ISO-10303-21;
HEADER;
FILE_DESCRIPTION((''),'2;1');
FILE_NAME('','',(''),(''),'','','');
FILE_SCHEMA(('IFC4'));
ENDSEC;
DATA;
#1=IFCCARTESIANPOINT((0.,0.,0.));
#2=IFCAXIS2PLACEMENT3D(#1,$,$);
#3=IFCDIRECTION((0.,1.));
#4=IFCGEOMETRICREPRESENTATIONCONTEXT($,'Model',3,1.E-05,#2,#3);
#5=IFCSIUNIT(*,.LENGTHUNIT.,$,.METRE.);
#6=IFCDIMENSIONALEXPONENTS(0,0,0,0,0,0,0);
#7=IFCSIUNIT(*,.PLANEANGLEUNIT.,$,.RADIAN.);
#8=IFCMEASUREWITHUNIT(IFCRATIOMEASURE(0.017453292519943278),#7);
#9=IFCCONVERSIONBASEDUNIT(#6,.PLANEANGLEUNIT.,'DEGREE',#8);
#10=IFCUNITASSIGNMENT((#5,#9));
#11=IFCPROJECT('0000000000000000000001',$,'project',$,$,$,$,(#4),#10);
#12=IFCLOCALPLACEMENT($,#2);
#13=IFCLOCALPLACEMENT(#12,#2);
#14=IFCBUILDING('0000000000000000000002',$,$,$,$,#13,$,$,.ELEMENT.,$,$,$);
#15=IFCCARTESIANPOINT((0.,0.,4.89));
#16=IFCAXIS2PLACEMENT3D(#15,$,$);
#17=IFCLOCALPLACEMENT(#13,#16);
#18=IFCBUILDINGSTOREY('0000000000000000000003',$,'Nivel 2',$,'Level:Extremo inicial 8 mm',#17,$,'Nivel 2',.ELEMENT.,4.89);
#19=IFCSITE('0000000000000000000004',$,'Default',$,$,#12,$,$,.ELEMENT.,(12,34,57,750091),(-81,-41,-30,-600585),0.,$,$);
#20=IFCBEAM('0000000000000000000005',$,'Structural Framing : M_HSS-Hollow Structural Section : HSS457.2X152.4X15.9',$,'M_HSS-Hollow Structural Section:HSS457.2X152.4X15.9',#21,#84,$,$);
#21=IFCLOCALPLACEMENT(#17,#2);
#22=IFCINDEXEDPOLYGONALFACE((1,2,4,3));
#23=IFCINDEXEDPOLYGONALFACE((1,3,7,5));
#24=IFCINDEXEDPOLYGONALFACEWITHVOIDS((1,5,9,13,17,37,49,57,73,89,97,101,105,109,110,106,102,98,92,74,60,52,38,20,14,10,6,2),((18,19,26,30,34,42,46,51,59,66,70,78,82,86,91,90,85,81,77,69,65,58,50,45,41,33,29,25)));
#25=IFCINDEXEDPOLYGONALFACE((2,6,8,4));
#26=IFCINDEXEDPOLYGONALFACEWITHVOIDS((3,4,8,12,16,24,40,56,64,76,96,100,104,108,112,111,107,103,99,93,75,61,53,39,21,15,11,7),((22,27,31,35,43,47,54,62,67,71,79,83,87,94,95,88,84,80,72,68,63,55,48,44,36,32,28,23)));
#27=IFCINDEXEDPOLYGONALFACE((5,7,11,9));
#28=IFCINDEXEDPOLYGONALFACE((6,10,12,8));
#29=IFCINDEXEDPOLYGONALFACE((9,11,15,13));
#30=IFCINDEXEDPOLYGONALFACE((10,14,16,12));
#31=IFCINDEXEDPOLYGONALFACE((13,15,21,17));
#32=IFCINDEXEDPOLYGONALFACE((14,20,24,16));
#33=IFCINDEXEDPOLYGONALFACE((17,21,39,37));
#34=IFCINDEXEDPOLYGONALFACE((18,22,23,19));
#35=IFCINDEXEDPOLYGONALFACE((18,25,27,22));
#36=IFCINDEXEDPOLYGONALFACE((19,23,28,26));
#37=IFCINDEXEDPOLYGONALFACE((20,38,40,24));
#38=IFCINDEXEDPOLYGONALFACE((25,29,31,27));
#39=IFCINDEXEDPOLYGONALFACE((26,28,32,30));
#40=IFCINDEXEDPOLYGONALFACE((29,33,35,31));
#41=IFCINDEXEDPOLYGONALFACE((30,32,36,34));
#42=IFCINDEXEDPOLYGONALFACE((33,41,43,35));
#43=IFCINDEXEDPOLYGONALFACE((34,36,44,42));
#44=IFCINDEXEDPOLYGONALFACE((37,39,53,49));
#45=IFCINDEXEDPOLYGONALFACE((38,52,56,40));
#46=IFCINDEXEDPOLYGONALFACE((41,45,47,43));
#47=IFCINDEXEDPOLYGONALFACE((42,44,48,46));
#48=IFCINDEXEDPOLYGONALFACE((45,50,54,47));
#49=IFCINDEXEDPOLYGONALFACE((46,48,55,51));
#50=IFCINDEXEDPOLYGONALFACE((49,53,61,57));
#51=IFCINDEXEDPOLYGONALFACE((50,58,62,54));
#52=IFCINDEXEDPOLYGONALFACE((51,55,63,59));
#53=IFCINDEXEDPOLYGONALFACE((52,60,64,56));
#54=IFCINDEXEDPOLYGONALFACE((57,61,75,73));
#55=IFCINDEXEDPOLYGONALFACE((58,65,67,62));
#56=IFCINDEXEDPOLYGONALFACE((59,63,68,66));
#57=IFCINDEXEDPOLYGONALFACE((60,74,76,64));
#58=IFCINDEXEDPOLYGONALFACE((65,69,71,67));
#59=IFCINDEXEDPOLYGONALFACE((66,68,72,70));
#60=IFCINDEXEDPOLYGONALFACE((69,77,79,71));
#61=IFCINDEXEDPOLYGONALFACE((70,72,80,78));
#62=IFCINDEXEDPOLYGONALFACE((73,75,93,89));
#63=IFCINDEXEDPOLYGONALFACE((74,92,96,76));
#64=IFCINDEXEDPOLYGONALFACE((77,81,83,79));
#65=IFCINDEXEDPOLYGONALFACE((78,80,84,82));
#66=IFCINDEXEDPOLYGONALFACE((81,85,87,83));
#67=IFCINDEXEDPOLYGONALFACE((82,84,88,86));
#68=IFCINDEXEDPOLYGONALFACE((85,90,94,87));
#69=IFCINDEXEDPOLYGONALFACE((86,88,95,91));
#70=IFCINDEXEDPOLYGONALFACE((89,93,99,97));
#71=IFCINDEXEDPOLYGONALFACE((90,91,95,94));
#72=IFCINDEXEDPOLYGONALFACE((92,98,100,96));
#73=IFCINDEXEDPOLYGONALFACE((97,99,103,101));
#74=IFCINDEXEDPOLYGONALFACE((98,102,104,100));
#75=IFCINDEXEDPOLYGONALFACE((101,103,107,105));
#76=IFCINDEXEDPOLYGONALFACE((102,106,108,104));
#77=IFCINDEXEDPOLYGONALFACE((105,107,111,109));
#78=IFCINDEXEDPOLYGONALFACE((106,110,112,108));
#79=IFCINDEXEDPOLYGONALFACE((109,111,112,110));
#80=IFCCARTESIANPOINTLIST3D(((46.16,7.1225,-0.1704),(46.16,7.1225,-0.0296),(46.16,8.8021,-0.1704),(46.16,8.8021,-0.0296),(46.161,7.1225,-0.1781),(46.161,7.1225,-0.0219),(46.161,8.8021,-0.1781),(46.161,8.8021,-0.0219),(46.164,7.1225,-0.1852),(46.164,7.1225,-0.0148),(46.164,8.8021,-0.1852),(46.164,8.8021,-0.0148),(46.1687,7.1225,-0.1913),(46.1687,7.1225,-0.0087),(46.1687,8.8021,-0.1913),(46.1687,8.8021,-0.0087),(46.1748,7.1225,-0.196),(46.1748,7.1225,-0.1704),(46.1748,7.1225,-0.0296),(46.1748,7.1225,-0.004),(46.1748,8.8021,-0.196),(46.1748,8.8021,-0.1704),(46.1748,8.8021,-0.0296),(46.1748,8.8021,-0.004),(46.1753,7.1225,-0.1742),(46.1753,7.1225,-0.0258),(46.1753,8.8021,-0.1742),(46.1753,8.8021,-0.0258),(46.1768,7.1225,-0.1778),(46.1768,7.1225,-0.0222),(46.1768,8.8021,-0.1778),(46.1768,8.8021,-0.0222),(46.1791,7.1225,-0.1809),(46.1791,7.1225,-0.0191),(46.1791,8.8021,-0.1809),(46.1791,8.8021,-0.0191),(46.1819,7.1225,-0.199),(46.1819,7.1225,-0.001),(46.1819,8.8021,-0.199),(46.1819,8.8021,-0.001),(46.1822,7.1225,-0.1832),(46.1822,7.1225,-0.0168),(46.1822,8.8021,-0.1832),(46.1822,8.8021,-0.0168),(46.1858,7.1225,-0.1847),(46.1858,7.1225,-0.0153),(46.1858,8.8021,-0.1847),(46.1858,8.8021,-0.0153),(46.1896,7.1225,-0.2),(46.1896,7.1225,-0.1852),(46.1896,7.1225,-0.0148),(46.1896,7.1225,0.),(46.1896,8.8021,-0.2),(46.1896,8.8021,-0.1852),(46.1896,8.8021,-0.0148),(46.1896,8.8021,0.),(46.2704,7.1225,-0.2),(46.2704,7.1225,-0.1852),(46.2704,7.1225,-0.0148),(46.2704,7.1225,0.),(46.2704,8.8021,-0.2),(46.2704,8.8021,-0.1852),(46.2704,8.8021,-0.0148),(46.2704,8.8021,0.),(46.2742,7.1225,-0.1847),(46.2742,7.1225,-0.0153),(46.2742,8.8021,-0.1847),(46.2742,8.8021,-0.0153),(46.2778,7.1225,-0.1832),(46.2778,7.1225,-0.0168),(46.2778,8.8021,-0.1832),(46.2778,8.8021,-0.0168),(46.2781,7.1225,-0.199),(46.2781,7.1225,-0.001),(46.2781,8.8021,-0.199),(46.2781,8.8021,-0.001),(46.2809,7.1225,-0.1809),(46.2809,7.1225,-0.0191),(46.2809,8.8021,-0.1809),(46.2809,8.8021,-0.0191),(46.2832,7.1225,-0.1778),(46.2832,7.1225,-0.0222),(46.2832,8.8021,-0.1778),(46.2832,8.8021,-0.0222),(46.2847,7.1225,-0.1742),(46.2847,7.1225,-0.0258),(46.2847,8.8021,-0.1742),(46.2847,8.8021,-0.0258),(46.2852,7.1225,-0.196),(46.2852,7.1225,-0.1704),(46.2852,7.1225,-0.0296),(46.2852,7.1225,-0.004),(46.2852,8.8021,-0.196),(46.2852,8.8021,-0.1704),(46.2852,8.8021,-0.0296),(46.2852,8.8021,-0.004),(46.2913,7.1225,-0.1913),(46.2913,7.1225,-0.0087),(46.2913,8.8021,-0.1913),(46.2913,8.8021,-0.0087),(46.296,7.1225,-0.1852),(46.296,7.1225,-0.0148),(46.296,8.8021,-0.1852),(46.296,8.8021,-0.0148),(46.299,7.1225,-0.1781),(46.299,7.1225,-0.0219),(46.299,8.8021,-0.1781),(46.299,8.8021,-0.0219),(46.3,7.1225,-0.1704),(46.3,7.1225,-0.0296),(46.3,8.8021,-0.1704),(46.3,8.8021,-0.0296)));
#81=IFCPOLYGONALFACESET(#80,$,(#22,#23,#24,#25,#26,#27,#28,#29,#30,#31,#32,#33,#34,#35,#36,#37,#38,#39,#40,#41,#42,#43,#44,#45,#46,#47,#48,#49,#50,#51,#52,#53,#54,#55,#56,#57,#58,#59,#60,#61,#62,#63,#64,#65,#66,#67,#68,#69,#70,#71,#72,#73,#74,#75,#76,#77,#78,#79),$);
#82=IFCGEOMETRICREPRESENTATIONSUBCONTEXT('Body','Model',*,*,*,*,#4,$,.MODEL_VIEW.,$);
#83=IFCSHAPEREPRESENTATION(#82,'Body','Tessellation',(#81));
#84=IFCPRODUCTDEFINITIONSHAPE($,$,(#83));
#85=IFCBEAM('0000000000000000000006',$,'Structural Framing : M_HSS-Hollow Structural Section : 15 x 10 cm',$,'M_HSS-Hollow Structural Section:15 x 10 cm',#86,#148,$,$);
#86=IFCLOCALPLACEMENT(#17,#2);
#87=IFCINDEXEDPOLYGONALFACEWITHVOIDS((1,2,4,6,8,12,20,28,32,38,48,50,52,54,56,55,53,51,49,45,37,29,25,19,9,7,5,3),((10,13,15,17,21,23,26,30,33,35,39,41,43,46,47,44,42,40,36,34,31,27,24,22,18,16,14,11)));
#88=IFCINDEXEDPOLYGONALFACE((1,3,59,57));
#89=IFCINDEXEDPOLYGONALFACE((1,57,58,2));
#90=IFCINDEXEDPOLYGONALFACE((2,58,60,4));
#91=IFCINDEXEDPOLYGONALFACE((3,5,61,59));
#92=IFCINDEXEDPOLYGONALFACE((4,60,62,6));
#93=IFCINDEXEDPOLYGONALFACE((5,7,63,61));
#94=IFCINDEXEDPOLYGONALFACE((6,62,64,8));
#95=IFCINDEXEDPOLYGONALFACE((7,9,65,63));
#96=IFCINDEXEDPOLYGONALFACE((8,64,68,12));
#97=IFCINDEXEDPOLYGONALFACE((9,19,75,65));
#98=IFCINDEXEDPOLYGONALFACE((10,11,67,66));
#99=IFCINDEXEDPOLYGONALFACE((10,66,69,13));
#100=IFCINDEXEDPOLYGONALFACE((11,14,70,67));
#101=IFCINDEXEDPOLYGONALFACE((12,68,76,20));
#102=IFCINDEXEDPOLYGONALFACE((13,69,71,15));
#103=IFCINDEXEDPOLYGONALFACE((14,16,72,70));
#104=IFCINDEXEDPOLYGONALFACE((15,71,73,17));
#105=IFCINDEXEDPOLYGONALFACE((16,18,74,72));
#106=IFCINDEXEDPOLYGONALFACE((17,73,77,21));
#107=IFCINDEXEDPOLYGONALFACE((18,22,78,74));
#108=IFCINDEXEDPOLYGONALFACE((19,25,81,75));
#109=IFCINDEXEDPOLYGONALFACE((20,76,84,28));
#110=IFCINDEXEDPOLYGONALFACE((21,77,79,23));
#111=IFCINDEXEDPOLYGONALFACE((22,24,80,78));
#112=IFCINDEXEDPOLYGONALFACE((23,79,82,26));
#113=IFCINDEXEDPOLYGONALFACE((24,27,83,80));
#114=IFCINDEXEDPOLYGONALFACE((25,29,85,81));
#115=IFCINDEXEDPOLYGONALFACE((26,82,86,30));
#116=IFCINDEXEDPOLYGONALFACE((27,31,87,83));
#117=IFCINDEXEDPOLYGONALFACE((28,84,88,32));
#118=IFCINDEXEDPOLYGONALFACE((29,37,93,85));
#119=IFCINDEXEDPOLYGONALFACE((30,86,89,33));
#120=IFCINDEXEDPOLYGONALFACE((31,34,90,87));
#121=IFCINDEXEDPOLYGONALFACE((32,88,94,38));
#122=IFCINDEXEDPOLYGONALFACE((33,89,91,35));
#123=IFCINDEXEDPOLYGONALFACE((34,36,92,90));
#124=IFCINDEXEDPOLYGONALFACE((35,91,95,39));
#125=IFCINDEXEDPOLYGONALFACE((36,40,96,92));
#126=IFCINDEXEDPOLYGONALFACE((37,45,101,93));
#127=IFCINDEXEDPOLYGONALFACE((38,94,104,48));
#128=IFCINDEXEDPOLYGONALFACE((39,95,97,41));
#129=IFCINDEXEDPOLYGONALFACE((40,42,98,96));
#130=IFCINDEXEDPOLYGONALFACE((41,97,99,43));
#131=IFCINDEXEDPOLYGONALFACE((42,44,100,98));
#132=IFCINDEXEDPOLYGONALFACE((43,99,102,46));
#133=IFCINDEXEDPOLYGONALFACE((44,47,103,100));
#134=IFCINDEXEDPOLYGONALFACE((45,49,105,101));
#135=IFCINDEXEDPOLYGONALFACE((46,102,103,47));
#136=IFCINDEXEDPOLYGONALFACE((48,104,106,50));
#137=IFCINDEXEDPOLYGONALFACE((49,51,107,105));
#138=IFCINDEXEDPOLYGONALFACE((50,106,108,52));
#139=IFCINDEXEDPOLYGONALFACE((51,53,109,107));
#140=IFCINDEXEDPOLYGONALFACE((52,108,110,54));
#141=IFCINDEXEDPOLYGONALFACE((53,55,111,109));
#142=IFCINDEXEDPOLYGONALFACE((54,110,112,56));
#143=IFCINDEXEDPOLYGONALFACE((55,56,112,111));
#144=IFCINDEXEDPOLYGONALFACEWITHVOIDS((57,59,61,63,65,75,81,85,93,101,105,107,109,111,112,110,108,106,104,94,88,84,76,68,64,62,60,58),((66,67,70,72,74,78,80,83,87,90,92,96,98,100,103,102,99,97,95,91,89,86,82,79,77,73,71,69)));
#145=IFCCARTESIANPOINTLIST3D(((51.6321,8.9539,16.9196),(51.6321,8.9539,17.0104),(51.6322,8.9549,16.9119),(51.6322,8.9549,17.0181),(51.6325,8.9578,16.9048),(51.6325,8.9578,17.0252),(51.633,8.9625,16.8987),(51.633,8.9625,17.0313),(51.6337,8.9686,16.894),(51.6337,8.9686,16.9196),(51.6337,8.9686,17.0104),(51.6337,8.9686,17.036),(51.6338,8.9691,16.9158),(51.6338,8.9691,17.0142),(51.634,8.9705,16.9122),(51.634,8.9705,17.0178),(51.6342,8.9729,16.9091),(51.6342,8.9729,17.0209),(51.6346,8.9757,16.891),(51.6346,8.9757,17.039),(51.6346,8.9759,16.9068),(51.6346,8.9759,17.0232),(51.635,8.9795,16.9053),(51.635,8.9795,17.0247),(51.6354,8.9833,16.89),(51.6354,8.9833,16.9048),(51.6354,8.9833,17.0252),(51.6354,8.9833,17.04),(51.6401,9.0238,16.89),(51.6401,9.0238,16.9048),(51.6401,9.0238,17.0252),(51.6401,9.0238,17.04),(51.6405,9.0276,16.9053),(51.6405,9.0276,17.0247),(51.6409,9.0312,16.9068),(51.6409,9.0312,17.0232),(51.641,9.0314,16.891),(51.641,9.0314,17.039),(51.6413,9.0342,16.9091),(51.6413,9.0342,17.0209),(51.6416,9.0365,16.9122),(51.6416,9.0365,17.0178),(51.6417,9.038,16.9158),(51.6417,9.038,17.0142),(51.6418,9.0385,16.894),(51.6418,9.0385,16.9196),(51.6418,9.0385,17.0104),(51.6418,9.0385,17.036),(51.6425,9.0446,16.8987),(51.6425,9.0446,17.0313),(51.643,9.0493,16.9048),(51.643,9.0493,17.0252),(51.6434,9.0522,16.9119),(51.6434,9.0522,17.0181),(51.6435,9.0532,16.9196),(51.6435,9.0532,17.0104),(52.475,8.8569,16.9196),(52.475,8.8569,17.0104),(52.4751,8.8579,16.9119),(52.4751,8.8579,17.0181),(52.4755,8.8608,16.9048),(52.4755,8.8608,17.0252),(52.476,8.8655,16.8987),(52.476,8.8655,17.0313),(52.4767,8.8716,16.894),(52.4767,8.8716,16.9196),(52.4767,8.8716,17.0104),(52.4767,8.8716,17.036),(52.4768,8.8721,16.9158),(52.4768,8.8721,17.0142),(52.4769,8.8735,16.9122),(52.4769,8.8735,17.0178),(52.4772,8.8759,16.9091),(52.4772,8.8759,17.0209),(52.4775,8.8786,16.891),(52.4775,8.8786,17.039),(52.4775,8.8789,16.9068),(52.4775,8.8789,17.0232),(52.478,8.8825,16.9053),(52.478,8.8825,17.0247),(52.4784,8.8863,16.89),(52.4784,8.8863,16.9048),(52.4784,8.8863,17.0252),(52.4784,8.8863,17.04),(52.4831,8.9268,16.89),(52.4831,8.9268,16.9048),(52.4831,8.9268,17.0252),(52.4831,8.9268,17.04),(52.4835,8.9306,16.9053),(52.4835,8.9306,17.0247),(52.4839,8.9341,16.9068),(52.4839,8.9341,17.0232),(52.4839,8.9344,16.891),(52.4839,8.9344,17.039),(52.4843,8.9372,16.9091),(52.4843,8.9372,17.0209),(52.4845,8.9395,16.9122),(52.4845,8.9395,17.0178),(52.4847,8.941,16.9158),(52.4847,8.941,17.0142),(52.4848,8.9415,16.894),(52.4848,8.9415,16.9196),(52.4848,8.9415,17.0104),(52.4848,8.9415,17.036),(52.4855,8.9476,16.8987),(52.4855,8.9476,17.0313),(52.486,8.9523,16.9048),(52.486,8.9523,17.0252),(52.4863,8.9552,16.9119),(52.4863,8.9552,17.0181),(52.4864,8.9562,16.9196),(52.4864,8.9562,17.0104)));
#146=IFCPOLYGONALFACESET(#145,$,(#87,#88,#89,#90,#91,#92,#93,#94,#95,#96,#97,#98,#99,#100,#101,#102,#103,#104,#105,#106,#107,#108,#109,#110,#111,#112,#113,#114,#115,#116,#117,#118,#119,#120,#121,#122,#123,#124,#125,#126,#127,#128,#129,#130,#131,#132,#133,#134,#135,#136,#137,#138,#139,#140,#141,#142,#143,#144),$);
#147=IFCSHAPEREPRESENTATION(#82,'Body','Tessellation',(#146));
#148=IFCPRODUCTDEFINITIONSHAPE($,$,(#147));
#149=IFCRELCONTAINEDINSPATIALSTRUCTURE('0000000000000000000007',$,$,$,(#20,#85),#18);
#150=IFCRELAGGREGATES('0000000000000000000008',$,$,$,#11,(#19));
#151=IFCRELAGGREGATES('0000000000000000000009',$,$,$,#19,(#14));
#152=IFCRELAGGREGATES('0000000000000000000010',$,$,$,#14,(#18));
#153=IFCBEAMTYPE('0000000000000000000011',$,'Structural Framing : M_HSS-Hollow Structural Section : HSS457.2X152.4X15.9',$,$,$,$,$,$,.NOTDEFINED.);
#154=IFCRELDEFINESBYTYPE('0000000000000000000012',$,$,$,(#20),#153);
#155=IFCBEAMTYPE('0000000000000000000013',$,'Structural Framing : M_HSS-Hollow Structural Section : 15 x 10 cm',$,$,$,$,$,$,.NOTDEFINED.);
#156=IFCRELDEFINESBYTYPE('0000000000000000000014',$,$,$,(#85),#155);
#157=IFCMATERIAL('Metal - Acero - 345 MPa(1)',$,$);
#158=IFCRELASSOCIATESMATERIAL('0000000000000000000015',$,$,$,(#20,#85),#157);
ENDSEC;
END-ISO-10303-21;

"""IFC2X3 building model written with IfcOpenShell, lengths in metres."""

from ifc_helpers import new_model, entity, si_unit, converted_unit, direction, frame, frame_2d, origin, place, context, subcontext, project, spatial, polyline, circle_curve, parameter, trimmed, segment, composite_curve, outline, extrude, material, type_object, element, save


model = new_model("IFC2X3")

# Units and contexts
model_context = context("Model", 3, precision=1e-05, world=origin(), true_north=direction((0.0, 1.0)))
body_context = subcontext(model_context, "Body", "Model", "MODEL_VIEW")
ifc_project = project(units=[si_unit("LENGTHUNIT", "METRE"), converted_unit("PLANEANGLEUNIT", "DEGREE", entity("IfcRatioMeasure", 0.017453292519943278), si_unit("PLANEANGLEUNIT", "RADIAN"), dimensions=[0, 0, 0, 0, 0, 0, 0])], contexts=[model_context])

# Site, building, storey
site_placement = place(None, origin())
site = spatial("IfcSite", under=ifc_project, at=site_placement, Name="Default", CompositionType="ELEMENT", RefLatitude=(12, 34, 57, 750091), RefLongitude=(-81, -41, -30, -600585), RefElevation=0.0)
building_placement = place(site_placement, origin())
building = spatial("IfcBuilding", under=site, at=building_placement, CompositionType="ELEMENT")
storey_placement = place(building_placement, frame((0.0, 0.0, 4.89)))
storey = spatial("IfcBuildingStorey", under=building, at=storey_placement, Name="Nivel 2", ObjectType="Level:Extremo inicial 8 mm", LongName="Nivel 2", CompositionType="ELEMENT", Elevation=4.89)

# Shared definitions
ifc_material_1 = material(Name="Metal - Acero - 345 MPa(1)")

# Beams
beam_type_1 = type_object("IfcBeamType", Name="Structural Framing : M_HSS-Hollow Structural Section : HSS457.2X152.4X15.9", PredefinedType="NOTDEFINED")
beam_1_placement = place(storey_placement, frame((46.23, 8.8823, 0.0), z_axis=(0.0, 0.0, 1.0), x_axis=(0.0, -1.0, 0.0)))
element("IfcBeam", 1, at=beam_1_placement, inside=storey, type_object=beam_type_1, material=ifc_material_1, Name="Structural Framing : M_HSS-Hollow Structural Section : HSS457.2X152.4X15.9", ObjectType="M_HSS-Hollow Structural Section:HSS457.2X152.4X15.9", context=body_context, shape_type="SweptSolid", body=[
    extrude(outline(composite_curve([segment(trimmed(circle_curve(frame_2d((0.0704, -0.0404), x_axis=(1.0, 0.0)), 0.0296), [parameter(270.0)], [parameter(360.0)], True, "PARAMETER"), True, "CONTINUOUS"), segment(polyline([(0.1, -0.0404), (0.1, 0.0404)]), True, "CONTINUOUS"), segment(trimmed(circle_curve(frame_2d((0.0704, 0.0404), x_axis=(0.0, 1.0)), 0.0296), [parameter(270.0)], [parameter(0.0)], True, "PARAMETER"), True, "CONTINUOUS"), segment(polyline([(0.0704, 0.07), (-0.0704, 0.07)]), True, "CONTINUOUS"), segment(trimmed(circle_curve(frame_2d((-0.0704, 0.0404), x_axis=(-1.0, 0.0)), 0.0296), [parameter(270.0)], [parameter(0.0)], True, "PARAMETER"), True, "CONTINUOUS"), segment(polyline([(-0.1, 0.0404), (-0.1, -0.0404)]), True, "CONTINUOUS"), segment(trimmed(circle_curve(frame_2d((-0.0704, -0.0404), x_axis=(0.0, -1.0)), 0.0296), [parameter(270.0)], [parameter(0.0)], True, "PARAMETER"), True, "CONTINUOUS"), segment(polyline([(-0.0704, -0.07), (0.0704, -0.07)]), True, "CONTINUOUS")], self_intersect=False), holes=[composite_curve([segment(polyline([(0.0852, 0.0404), (0.0852, -0.0404)]), True, "CONTINUOUS"), segment(trimmed(circle_curve(frame_2d((0.0704, -0.0404), x_axis=(0.0, -1.0)), 0.0148), [parameter(0.0)], [parameter(90.0)], True, "PARAMETER"), False, "CONTINUOUS"), segment(polyline([(0.0704, -0.0552), (-0.0704, -0.0552)]), True, "CONTINUOUS"), segment(trimmed(circle_curve(frame_2d((-0.0704, -0.0404), x_axis=(-1.0, 0.0)), 0.0148), [parameter(0.0)], [parameter(90.0)], True, "PARAMETER"), False, "CONTINUOUS"), segment(polyline([(-0.0852, -0.0404), (-0.0852, 0.0404)]), True, "CONTINUOUS"), segment(trimmed(circle_curve(frame_2d((-0.0704, 0.0404), x_axis=(0.0, 1.0)), 0.0148), [parameter(0.0)], [parameter(90.0)], True, "PARAMETER"), False, "CONTINUOUS"), segment(polyline([(-0.0704, 0.0552), (0.0704, 0.0552)]), True, "CONTINUOUS"), segment(trimmed(circle_curve(frame_2d((0.0704, 0.0404), x_axis=(1.0, 0.0)), 0.0148), [parameter(0.0)], [parameter(90.0)], True, "PARAMETER"), False, "CONTINUOUS")], self_intersect=False)]), frame((0.0802, 0.0, -0.1), z_axis=(1.0, 0.0, 0.0), x_axis=(0.0, 0.0, 1.0)), (0.0, 0.0, 1.0), 1.6796),
])
beam_type_2 = type_object("IfcBeamType", Name="Structural Framing : M_HSS-Hollow Structural Section : 15 x 10 cm", PredefinedType="NOTDEFINED")
beam_2_placement = place(storey_placement, frame((52.8284, 8.8665, 17.04), z_axis=(0.0, 0.0, 1.0), x_axis=(-0.993441, 0.114344, 0.0)))
element("IfcBeam", 2, at=beam_2_placement, inside=storey, type_object=beam_type_2, material=ifc_material_1, Name="Structural Framing : M_HSS-Hollow Structural Section : 15 x 10 cm", ObjectType="M_HSS-Hollow Structural Section:15 x 10 cm", context=body_context, shape_type="SweptSolid", body=[
    extrude(outline(composite_curve([segment(trimmed(circle_curve(frame_2d((-0.0204, -0.0454), x_axis=(1.0, 0.0)), 0.0296), [parameter(180.0)], [parameter(270.0)], True, "PARAMETER"), True, "CONTINUOUS"), segment(polyline([(-0.0204, -0.075), (0.0204, -0.075)]), True, "CONTINUOUS"), segment(trimmed(circle_curve(frame_2d((0.0204, -0.0454), x_axis=(1.0, 0.0)), 0.0296), [parameter(270.0)], [parameter(0.0)], True, "PARAMETER"), True, "CONTINUOUS"), segment(polyline([(0.05, -0.0454), (0.05, 0.0454)]), True, "CONTINUOUS"), segment(trimmed(circle_curve(frame_2d((0.0204, 0.0454), x_axis=(1.0, 0.0)), 0.0296), [parameter(360.0)], [parameter(90.0)], True, "PARAMETER"), True, "CONTINUOUS"), segment(polyline([(0.0204, 0.075), (-0.0204, 0.075)]), True, "CONTINUOUS"), segment(trimmed(circle_curve(frame_2d((-0.0204, 0.0454), x_axis=(1.0, 0.0)), 0.0296), [parameter(90.0)], [parameter(180.0)], True, "PARAMETER"), True, "CONTINUOUS"), segment(polyline([(-0.05, 0.0454), (-0.05, -0.0454)]), True, "CONTINUOUS")], self_intersect=False), holes=[composite_curve([segment(polyline([(0.0204, -0.0602), (-0.0204, -0.0602)]), True, "CONTINUOUS"), segment(trimmed(circle_curve(frame_2d((-0.0204, -0.0454), x_axis=(1.0, 0.0)), 0.0148), [parameter(180.0)], [parameter(270.0)], True, "PARAMETER"), False, "CONTINUOUS"), segment(polyline([(-0.0352, -0.0454), (-0.0352, 0.0454)]), True, "CONTINUOUS"), segment(trimmed(circle_curve(frame_2d((-0.0204, 0.0454), x_axis=(1.0, 0.0)), 0.0148), [parameter(90.0)], [parameter(180.0)], True, "PARAMETER"), False, "CONTINUOUS"), segment(polyline([(-0.0204, 0.0602), (0.0204, 0.0602)]), True, "CONTINUOUS"), segment(trimmed(circle_curve(frame_2d((0.0204, 0.0454), x_axis=(1.0, 0.0)), 0.0148), [parameter(0.0)], [parameter(90.0)], True, "PARAMETER"), False, "CONTINUOUS"), segment(polyline([(0.0352, 0.0454), (0.0352, -0.0454)]), True, "CONTINUOUS"), segment(trimmed(circle_curve(frame_2d((0.0204, -0.0454), x_axis=(1.0, 0.0)), 0.0148), [parameter(270.0)], [parameter(0.0)], True, "PARAMETER"), False, "CONTINUOUS")], self_intersect=False)]), frame((0.35, 0.0, -0.075), z_axis=(1.0, 0.0, 0.0), x_axis=(0.0, -1.0, 0.0)), (0.0, 0.0, 1.0), 0.8485),
])

save(model, "model.ifc")
